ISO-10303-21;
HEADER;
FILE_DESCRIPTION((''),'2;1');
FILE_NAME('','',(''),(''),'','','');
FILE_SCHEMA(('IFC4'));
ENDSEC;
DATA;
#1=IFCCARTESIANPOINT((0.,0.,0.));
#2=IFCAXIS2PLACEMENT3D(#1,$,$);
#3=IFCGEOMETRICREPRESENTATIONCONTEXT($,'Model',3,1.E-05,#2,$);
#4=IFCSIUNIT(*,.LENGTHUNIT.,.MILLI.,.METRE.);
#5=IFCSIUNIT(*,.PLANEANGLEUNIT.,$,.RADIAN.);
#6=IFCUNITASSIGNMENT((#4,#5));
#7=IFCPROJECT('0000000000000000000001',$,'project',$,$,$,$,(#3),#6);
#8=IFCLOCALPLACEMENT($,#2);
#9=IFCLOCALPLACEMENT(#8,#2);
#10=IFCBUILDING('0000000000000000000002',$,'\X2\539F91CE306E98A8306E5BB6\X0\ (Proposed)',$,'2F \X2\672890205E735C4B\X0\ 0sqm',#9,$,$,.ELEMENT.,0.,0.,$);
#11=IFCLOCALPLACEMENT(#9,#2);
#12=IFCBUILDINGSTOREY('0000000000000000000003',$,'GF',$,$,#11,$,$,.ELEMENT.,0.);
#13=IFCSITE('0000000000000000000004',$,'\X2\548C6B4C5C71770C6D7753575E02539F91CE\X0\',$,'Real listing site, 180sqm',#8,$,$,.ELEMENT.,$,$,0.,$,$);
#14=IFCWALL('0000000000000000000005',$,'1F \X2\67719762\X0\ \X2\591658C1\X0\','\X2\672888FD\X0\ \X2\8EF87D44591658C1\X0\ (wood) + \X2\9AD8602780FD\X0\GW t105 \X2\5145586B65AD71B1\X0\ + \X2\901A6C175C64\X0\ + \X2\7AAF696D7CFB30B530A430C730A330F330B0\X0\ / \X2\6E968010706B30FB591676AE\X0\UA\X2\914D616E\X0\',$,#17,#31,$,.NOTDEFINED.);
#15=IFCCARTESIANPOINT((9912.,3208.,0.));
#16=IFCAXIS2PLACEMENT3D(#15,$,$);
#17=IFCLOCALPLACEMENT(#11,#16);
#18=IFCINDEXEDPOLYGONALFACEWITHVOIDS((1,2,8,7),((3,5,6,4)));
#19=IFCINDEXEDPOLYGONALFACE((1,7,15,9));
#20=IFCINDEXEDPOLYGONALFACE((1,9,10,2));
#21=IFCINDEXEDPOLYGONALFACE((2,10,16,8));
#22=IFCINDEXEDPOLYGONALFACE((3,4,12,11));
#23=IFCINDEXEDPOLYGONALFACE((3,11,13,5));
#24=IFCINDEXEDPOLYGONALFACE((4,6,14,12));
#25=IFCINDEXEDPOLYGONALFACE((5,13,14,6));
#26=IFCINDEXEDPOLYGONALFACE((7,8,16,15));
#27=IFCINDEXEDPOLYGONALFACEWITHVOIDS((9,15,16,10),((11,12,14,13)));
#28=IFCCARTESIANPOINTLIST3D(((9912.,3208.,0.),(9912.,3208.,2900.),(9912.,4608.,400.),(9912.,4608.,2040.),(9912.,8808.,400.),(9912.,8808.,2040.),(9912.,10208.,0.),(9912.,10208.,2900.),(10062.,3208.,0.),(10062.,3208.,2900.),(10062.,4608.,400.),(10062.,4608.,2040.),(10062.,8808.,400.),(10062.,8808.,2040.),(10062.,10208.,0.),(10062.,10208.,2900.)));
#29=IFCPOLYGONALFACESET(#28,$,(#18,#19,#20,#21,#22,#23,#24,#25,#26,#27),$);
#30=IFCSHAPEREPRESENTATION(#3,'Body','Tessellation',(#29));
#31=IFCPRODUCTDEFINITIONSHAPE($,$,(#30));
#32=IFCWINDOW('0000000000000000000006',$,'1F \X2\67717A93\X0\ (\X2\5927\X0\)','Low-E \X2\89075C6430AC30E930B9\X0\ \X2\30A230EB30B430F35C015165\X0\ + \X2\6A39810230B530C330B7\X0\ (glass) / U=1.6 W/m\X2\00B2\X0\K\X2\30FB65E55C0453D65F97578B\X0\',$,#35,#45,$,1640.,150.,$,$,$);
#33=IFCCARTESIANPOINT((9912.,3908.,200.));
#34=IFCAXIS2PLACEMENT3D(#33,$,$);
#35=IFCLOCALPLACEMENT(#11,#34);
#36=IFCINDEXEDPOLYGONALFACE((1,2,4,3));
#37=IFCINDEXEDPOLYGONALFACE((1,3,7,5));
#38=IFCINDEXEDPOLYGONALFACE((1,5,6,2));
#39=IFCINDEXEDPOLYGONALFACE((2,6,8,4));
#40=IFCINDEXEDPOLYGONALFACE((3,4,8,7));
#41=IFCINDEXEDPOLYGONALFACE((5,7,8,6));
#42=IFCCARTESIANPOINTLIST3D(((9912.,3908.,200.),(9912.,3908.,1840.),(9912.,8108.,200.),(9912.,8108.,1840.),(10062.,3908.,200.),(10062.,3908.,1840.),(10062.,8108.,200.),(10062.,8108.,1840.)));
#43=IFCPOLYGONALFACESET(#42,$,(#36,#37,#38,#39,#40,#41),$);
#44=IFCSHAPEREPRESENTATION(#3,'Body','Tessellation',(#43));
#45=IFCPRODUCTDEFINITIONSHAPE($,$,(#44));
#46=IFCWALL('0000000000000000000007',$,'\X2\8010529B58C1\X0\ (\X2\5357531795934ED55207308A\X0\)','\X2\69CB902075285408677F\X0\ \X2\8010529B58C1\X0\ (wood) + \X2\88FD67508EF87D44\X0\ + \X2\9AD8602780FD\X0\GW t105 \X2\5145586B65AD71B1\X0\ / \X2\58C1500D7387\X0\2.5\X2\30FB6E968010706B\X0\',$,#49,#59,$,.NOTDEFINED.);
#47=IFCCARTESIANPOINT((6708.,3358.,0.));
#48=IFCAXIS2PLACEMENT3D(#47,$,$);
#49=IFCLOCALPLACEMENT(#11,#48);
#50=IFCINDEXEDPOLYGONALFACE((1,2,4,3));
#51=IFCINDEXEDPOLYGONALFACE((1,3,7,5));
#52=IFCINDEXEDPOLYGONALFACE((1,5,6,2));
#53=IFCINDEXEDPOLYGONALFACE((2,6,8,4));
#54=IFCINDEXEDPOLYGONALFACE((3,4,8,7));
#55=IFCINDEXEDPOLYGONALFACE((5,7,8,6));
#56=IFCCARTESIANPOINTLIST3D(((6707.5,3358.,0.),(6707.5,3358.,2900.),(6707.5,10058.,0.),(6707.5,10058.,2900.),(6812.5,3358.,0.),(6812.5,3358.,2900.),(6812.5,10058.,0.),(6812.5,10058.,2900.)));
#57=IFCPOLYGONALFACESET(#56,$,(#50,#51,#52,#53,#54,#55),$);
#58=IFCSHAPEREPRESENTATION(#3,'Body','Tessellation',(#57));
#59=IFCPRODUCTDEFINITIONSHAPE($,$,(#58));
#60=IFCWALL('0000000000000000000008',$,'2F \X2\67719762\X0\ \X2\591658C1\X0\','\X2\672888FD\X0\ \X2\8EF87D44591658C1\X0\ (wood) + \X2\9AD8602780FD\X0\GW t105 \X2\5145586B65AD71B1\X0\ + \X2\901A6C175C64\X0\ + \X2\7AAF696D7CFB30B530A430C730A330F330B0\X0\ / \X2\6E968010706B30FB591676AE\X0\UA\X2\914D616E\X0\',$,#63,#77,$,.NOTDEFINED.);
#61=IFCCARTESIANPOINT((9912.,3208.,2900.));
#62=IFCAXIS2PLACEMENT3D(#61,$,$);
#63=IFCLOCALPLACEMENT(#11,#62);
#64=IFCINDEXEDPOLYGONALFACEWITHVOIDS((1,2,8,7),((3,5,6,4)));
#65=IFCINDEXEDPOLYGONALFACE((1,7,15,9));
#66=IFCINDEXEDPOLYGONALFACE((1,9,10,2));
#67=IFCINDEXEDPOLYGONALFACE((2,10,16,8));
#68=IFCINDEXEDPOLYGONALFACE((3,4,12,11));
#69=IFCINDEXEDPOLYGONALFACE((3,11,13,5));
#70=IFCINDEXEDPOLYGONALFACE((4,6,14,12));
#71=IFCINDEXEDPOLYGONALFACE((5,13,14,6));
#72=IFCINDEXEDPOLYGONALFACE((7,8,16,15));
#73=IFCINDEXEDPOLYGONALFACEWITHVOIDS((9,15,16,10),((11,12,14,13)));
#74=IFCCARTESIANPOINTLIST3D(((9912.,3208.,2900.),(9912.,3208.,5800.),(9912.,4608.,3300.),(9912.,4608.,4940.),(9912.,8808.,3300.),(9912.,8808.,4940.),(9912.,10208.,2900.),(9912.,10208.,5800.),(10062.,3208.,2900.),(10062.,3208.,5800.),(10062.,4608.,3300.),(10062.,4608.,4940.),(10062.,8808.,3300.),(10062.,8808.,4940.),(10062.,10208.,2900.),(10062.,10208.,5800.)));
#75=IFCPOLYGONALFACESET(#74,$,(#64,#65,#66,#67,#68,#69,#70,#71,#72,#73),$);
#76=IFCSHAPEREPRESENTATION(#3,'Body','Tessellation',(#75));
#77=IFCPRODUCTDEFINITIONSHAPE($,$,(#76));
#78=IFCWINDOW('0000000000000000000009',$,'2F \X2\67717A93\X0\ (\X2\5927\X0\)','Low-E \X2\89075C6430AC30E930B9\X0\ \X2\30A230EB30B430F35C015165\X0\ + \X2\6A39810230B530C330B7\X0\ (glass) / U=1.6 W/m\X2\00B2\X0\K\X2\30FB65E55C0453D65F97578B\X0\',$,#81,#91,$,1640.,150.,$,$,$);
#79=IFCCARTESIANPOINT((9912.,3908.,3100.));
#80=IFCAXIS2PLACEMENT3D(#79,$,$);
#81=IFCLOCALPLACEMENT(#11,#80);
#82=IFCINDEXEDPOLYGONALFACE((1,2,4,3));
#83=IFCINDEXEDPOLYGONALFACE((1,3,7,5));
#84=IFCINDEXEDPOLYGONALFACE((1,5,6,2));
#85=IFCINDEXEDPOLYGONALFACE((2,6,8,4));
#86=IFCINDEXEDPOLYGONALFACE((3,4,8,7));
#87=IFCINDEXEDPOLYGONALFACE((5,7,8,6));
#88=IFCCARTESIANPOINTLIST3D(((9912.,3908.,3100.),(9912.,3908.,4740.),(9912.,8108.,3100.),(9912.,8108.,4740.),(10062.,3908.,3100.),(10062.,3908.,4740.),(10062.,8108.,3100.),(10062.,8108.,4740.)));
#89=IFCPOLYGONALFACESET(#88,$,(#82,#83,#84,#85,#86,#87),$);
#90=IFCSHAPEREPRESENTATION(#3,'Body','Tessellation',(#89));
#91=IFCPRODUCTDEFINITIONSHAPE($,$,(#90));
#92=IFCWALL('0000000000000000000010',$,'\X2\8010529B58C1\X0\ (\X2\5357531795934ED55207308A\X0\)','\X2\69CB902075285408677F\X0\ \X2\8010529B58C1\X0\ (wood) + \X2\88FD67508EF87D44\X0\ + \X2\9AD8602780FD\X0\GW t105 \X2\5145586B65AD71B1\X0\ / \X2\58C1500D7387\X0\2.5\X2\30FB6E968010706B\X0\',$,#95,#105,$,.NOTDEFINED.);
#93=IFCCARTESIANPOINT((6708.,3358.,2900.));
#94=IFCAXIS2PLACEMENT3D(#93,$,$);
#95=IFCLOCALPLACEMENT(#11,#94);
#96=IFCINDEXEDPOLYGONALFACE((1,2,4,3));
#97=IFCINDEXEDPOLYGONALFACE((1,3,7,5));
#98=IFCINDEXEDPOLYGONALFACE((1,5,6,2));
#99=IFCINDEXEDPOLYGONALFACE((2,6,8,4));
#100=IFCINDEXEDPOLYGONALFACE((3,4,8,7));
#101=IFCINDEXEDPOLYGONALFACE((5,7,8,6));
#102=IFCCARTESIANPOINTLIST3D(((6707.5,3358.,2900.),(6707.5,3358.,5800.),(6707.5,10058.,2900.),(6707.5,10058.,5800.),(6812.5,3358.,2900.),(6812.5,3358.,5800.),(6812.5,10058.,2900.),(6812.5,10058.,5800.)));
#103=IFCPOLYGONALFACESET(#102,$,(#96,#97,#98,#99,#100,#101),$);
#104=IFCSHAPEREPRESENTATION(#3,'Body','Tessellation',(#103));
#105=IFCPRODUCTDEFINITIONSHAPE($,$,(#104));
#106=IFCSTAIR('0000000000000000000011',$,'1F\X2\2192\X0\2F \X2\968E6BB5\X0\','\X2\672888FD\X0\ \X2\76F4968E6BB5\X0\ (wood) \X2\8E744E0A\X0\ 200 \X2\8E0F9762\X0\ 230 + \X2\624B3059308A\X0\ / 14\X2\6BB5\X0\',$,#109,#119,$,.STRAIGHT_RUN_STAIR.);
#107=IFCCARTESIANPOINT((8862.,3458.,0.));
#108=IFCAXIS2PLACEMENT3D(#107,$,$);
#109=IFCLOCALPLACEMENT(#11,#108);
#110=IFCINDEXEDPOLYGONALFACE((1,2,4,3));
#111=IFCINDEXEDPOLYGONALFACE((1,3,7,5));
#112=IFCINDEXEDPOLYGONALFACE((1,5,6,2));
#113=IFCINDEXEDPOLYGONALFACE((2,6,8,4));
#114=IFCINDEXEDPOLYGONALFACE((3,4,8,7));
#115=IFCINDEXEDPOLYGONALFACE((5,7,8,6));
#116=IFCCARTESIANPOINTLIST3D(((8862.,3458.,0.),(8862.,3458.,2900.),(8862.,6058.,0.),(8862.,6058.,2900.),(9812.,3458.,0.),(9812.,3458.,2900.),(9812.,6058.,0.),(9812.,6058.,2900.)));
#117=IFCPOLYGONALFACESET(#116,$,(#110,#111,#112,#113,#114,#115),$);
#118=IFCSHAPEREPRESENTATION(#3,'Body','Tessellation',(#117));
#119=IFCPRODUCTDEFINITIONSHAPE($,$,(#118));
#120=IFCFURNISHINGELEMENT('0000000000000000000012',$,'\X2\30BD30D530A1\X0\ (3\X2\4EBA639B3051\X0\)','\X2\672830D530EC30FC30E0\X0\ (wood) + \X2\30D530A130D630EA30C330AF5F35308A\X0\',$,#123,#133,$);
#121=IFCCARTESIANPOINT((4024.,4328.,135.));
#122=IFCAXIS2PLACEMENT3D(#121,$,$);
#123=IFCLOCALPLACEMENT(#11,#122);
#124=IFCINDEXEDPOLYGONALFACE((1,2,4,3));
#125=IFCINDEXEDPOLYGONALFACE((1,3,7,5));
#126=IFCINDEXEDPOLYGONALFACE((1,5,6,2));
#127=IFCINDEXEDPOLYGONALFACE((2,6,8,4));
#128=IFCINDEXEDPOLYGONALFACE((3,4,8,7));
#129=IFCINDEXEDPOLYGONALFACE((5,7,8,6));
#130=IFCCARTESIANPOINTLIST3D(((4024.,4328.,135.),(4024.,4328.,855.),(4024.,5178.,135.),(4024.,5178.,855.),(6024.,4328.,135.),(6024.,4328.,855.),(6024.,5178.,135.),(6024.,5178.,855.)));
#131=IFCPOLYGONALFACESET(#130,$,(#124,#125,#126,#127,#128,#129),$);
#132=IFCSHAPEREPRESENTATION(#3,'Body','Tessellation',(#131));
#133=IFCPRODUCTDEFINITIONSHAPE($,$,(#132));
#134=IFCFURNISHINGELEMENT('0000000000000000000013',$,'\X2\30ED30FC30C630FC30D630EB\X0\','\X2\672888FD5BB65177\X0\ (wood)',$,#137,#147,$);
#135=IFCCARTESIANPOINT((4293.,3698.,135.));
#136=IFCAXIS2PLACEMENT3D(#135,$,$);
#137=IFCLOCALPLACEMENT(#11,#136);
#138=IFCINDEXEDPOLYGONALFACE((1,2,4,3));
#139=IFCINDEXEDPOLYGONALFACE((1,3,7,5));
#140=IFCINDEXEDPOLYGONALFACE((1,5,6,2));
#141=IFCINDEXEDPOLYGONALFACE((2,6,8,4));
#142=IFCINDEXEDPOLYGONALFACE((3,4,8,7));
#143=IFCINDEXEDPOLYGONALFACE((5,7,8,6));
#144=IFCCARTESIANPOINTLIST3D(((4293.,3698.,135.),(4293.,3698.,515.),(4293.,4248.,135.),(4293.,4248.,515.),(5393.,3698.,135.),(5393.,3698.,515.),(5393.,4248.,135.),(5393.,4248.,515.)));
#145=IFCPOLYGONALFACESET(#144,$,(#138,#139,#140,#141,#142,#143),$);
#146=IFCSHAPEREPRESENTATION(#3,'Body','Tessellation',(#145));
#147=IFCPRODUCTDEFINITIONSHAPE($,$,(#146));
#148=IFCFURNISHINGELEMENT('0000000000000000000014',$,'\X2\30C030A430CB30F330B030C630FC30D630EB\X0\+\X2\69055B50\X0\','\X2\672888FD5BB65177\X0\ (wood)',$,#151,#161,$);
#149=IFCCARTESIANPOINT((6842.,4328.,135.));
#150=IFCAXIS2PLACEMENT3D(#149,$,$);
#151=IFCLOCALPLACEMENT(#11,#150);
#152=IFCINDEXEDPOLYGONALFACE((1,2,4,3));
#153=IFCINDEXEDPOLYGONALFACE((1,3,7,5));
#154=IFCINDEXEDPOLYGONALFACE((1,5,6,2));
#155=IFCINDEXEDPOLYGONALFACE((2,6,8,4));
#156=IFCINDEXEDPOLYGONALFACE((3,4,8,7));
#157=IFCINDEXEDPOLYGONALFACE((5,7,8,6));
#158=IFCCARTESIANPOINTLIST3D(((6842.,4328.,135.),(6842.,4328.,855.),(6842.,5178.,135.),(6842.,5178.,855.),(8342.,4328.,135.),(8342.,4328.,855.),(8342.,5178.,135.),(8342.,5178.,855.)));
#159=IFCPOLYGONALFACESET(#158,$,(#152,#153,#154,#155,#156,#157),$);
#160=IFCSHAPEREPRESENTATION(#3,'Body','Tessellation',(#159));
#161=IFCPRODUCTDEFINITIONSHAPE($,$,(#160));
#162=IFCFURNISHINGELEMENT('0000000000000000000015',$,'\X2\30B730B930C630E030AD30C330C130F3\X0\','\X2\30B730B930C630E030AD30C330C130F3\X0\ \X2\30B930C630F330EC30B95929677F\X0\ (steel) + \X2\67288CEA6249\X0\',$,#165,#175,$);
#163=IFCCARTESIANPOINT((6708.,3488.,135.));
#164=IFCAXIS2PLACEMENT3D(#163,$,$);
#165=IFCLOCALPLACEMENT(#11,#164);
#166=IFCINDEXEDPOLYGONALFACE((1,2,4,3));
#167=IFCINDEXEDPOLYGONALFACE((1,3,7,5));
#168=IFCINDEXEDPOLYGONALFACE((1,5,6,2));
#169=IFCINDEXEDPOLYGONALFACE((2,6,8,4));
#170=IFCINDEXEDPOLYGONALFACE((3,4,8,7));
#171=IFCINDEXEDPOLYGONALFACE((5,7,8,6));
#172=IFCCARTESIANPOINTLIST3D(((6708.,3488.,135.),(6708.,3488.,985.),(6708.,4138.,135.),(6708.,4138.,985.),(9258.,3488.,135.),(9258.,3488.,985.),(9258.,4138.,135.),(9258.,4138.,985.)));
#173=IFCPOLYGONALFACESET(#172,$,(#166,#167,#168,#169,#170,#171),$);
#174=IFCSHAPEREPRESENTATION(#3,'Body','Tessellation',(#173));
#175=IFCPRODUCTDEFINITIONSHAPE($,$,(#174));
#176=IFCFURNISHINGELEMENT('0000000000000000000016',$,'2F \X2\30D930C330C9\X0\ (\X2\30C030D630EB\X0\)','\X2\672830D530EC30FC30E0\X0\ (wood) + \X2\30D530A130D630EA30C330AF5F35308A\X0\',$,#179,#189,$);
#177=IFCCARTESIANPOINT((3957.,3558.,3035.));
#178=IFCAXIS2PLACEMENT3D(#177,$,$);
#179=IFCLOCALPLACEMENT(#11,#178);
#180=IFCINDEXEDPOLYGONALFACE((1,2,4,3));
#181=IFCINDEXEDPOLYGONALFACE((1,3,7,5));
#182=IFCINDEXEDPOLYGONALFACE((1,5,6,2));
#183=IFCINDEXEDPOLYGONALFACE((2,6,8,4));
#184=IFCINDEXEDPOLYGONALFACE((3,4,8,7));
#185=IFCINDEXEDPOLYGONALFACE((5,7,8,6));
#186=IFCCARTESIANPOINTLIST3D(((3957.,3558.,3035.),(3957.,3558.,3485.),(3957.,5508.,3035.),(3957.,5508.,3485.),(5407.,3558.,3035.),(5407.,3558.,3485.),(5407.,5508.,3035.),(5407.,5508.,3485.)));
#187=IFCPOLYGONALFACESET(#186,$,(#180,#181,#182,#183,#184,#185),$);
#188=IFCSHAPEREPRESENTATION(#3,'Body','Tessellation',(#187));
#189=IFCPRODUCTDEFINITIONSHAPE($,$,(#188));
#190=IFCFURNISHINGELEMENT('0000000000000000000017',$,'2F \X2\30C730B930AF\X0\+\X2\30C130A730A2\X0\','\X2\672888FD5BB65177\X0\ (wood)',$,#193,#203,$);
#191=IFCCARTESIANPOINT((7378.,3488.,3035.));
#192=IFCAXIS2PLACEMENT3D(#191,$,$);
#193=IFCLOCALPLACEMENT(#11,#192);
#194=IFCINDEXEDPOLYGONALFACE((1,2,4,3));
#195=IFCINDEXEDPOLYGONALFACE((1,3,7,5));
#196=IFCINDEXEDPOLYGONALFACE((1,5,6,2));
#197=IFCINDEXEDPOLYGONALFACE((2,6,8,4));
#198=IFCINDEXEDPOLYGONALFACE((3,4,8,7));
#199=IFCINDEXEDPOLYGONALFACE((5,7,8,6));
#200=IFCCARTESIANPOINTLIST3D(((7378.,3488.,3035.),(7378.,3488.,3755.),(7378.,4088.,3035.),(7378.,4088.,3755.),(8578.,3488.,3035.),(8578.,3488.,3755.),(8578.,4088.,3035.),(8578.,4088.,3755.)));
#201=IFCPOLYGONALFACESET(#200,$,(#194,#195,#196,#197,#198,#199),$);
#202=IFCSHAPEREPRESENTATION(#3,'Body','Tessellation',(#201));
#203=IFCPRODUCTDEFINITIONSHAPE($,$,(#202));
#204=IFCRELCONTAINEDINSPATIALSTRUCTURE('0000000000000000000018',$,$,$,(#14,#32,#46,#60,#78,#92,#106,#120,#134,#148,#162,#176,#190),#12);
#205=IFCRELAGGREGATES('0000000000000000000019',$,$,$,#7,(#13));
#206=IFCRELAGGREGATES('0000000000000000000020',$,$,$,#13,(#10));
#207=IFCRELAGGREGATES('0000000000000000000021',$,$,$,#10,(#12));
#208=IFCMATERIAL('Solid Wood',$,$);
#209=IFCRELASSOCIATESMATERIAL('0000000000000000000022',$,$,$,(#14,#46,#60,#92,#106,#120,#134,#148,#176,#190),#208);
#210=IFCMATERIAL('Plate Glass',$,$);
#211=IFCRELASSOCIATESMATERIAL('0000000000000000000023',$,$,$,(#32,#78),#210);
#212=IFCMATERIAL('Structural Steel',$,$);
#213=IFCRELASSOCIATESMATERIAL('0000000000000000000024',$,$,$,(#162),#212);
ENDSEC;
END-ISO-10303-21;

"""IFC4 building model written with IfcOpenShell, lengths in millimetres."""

from ifc_helpers import new_model, si_unit, frame, frame_2d, origin, place, context, project, spatial, rectangle, extrude, material, element, fill, save


model = new_model("IFC4")

# Units and contexts
model_context = context("Model", 3, precision=1e-05, world=origin())
ifc_project = project(units=[si_unit("LENGTHUNIT", "METRE", prefix="MILLI"), si_unit("PLANEANGLEUNIT", "RADIAN")], contexts=[model_context])

# Site, building, storey
site_placement = place(None, origin())
site = spatial("IfcSite", under=ifc_project, at=site_placement, Name="和歌山県海南市原野", ObjectType="Real listing site, 180sqm", CompositionType="ELEMENT", RefElevation=0.0)
building_placement = place(site_placement, origin())
building = spatial("IfcBuilding", under=site, at=building_placement, Name="原野の風の家 (Proposed)", ObjectType="2F 木造平屋 0sqm", CompositionType="ELEMENT", ElevationOfRefHeight=0.0, ElevationOfTerrain=0.0)
storey_placement = place(building_placement, origin())
storey = spatial("IfcBuildingStorey", under=building, at=storey_placement, Name="GF", CompositionType="ELEMENT", Elevation=0.0)

# Wall, opening, window
ifc_material_1 = material(Name="Solid Wood")
wall_1_placement = place(storey_placement, frame((9912.0, 3208.0, 0.0)))
wall_1 = element("IfcWall", 1, at=wall_1_placement, inside=storey, material=ifc_material_1, Name="1F 東面 外壁", Description="木製 軸組外壁 (wood) + 高性能GW t105 充填断熱 + 通気層 + 窯業系サイディング / 準耐火・外皮UA配慮", PredefinedType="NOTDEFINED", context=model_context, shape_type="SweptSolid", body=[
    extrude(rectangle(XDim=150.0, YDim=7000.0, at=frame_2d((75.0, 3500.0))), frame((9912.0, 3208.0, 0.0)), (0.0, 0.0, 1.0), 2900.0),
])
opening_1_placement = place(storey_placement, frame((9912.0, 3908.0, 200.0)))
opening_1 = element("IfcOpeningElement", 2, at=opening_1_placement, cuts=wall_1, PredefinedType="NOTDEFINED", context=model_context, shape_type="SweptSolid", body=[
    extrude(rectangle(XDim=150.0, YDim=4200.0, at=frame_2d((75.0, 2100.0))), frame((9912.0, 3908.0, 200.0)), (0.0, 0.0, 1.0), 1640.0),
])
ifc_material_2 = material(Name="Plate Glass")
window_1_placement = place(storey_placement, frame((9912.0, 3908.0, 200.0)))
window_1 = element("IfcWindow", 3, at=window_1_placement, inside=storey, material=ifc_material_2, Name="1F 東窓 (大)", Description="Low-E 複層ガラス アルゴン封入 + 樹脂サッシ (glass) / U=1.6 W/m²K・日射取得型", OverallHeight=1640.0, OverallWidth=150.0, context=model_context, shape_type="SweptSolid", body=[
    extrude(rectangle(XDim=150.0, YDim=4200.0, at=frame_2d((75.0, 2100.0))), frame((9912.0, 3908.0, 200.0)), (0.0, 0.0, 1.0), 1640.0),
])
fill(opening_1, window_1)

# Wall
wall_2_placement = place(storey_placement, frame((6708.0, 3358.0, 0.0)))
element("IfcWall", 4, at=wall_2_placement, inside=storey, material=ifc_material_1, Name="耐力壁 (南北間仕切り)", Description="構造用合板 耐力壁 (wood) + 製材軸組 + 高性能GW t105 充填断熱 / 壁倍率2.5・準耐火", PredefinedType="NOTDEFINED", context=model_context, shape_type="SweptSolid", body=[
    extrude(rectangle(XDim=105.0, YDim=6700.0, at=frame_2d((52.0, 3350.0))), frame((6708.0, 3358.0, 0.0)), (0.0, 0.0, 1.0), 2900.0),
])

# Wall, opening, window
wall_3_placement = place(storey_placement, frame((9912.0, 3208.0, 2900.0)))
wall_3 = element("IfcWall", 5, at=wall_3_placement, inside=storey, material=ifc_material_1, Name="2F 東面 外壁", Description="木製 軸組外壁 (wood) + 高性能GW t105 充填断熱 + 通気層 + 窯業系サイディング / 準耐火・外皮UA配慮", PredefinedType="NOTDEFINED", context=model_context, shape_type="SweptSolid", body=[
    extrude(rectangle(XDim=150.0, YDim=7000.0, at=frame_2d((75.0, 3500.0))), frame((9912.0, 3208.0, 2900.0)), (0.0, 0.0, 1.0), 2900.0),
])
opening_2_placement = place(storey_placement, frame((9912.0, 3908.0, 3100.0)))
opening_2 = element("IfcOpeningElement", 6, at=opening_2_placement, cuts=wall_3, PredefinedType="NOTDEFINED", context=model_context, shape_type="SweptSolid", body=[
    extrude(rectangle(XDim=150.0, YDim=4200.0, at=frame_2d((75.0, 2100.0))), frame((9912.0, 3908.0, 3100.0)), (0.0, 0.0, 1.0), 1640.0),
])
window_2_placement = place(storey_placement, frame((9912.0, 3908.0, 3100.0)))
window_2 = element("IfcWindow", 7, at=window_2_placement, inside=storey, material=ifc_material_2, Name="2F 東窓 (大)", Description="Low-E 複層ガラス アルゴン封入 + 樹脂サッシ (glass) / U=1.6 W/m²K・日射取得型", OverallHeight=1640.0, OverallWidth=150.0, context=model_context, shape_type="SweptSolid", body=[
    extrude(rectangle(XDim=150.0, YDim=4200.0, at=frame_2d((75.0, 2100.0))), frame((9912.0, 3908.0, 3100.0)), (0.0, 0.0, 1.0), 1640.0),
])
fill(opening_2, window_2)

# Wall
wall_4_placement = place(storey_placement, frame((6708.0, 3358.0, 2900.0)))
element("IfcWall", 8, at=wall_4_placement, inside=storey, material=ifc_material_1, Name="耐力壁 (南北間仕切り)", Description="構造用合板 耐力壁 (wood) + 製材軸組 + 高性能GW t105 充填断熱 / 壁倍率2.5・準耐火", PredefinedType="NOTDEFINED", context=model_context, shape_type="SweptSolid", body=[
    extrude(rectangle(XDim=105.0, YDim=6700.0, at=frame_2d((52.0, 3350.0))), frame((6708.0, 3358.0, 2900.0)), (0.0, 0.0, 1.0), 2900.0),
])

# Stair
stair_placement = place(storey_placement, frame((8862.0, 3458.0, 0.0)))
element("IfcStair", 9, at=stair_placement, inside=storey, material=ifc_material_1, Name="1F→2F 階段", Description="木製 直階段 (wood) 蹴上 200 踏面 230 + 手すり / 14段", PredefinedType="STRAIGHT_RUN_STAIR", context=model_context, shape_type="SweptSolid", body=[
    extrude(rectangle(XDim=950.0, YDim=2600.0, at=frame_2d((475.0, 1300.0))), frame((8862.0, 3458.0, 0.0)), (0.0, 0.0, 1.0), 2900.0),
])

# Furnishing elements
furnishing_1_placement = place(storey_placement, frame((4024.0, 4328.0, 135.0)))
element("IfcFurnishingElement", 10, at=furnishing_1_placement, inside=storey, material=ifc_material_1, Name="ソファ (3人掛け)", Description="木フレーム (wood) + ファブリック張り", context=model_context, shape_type="SweptSolid", body=[
    extrude(rectangle(XDim=2000.0, YDim=850.0, at=frame_2d((1000.0, 425.0))), frame((4024.0, 4328.0, 135.0)), (0.0, 0.0, 1.0), 720.0),
])
furnishing_2_placement = place(storey_placement, frame((4293.0, 3698.0, 135.0)))
element("IfcFurnishingElement", 11, at=furnishing_2_placement, inside=storey, material=ifc_material_1, Name="ローテーブル", Description="木製家具 (wood)", context=model_context, shape_type="SweptSolid", body=[
    extrude(rectangle(XDim=1100.0, YDim=550.0, at=frame_2d((550.0, 275.0))), frame((4293.0, 3698.0, 135.0)), (0.0, 0.0, 1.0), 380.0),
])
furnishing_3_placement = place(storey_placement, frame((6842.0, 4328.0, 135.0)))
element("IfcFurnishingElement", 12, at=furnishing_3_placement, inside=storey, material=ifc_material_1, Name="ダイニングテーブル+椅子", Description="木製家具 (wood)", context=model_context, shape_type="SweptSolid", body=[
    extrude(rectangle(XDim=1500.0, YDim=850.0, at=frame_2d((750.0, 425.0))), frame((6842.0, 4328.0, 135.0)), (0.0, 0.0, 1.0), 720.0),
])
ifc_material_3 = material(Name="Structural Steel")
furnishing_4_placement = place(storey_placement, frame((6708.0, 3488.0, 135.0)))
element("IfcFurnishingElement", 13, at=furnishing_4_placement, inside=storey, material=ifc_material_3, Name="システムキッチン", Description="システムキッチン ステンレス天板 (steel) + 木質扉", context=model_context, shape_type="SweptSolid", body=[
    extrude(rectangle(XDim=2550.0, YDim=650.0, at=frame_2d((1275.0, 325.0))), frame((6708.0, 3488.0, 135.0)), (0.0, 0.0, 1.0), 850.0),
])
furnishing_5_placement = place(storey_placement, frame((3957.0, 3558.0, 3035.0)))
element("IfcFurnishingElement", 14, at=furnishing_5_placement, inside=storey, material=ifc_material_1, Name="2F ベッド (ダブル)", Description="木フレーム (wood) + ファブリック張り", context=model_context, shape_type="SweptSolid", body=[
    extrude(rectangle(XDim=1450.0, YDim=1950.0, at=frame_2d((725.0, 975.0))), frame((3957.0, 3558.0, 3035.0)), (0.0, 0.0, 1.0), 450.0),
])
furnishing_6_placement = place(storey_placement, frame((7378.0, 3488.0, 3035.0)))
element("IfcFurnishingElement", 15, at=furnishing_6_placement, inside=storey, material=ifc_material_1, Name="2F デスク+チェア", Description="木製家具 (wood)", context=model_context, shape_type="SweptSolid", body=[
    extrude(rectangle(XDim=1200.0, YDim=600.0, at=frame_2d((600.0, 300.0))), frame((7378.0, 3488.0, 3035.0)), (0.0, 0.0, 1.0), 720.0),
])

save(model, "model.ifc")
